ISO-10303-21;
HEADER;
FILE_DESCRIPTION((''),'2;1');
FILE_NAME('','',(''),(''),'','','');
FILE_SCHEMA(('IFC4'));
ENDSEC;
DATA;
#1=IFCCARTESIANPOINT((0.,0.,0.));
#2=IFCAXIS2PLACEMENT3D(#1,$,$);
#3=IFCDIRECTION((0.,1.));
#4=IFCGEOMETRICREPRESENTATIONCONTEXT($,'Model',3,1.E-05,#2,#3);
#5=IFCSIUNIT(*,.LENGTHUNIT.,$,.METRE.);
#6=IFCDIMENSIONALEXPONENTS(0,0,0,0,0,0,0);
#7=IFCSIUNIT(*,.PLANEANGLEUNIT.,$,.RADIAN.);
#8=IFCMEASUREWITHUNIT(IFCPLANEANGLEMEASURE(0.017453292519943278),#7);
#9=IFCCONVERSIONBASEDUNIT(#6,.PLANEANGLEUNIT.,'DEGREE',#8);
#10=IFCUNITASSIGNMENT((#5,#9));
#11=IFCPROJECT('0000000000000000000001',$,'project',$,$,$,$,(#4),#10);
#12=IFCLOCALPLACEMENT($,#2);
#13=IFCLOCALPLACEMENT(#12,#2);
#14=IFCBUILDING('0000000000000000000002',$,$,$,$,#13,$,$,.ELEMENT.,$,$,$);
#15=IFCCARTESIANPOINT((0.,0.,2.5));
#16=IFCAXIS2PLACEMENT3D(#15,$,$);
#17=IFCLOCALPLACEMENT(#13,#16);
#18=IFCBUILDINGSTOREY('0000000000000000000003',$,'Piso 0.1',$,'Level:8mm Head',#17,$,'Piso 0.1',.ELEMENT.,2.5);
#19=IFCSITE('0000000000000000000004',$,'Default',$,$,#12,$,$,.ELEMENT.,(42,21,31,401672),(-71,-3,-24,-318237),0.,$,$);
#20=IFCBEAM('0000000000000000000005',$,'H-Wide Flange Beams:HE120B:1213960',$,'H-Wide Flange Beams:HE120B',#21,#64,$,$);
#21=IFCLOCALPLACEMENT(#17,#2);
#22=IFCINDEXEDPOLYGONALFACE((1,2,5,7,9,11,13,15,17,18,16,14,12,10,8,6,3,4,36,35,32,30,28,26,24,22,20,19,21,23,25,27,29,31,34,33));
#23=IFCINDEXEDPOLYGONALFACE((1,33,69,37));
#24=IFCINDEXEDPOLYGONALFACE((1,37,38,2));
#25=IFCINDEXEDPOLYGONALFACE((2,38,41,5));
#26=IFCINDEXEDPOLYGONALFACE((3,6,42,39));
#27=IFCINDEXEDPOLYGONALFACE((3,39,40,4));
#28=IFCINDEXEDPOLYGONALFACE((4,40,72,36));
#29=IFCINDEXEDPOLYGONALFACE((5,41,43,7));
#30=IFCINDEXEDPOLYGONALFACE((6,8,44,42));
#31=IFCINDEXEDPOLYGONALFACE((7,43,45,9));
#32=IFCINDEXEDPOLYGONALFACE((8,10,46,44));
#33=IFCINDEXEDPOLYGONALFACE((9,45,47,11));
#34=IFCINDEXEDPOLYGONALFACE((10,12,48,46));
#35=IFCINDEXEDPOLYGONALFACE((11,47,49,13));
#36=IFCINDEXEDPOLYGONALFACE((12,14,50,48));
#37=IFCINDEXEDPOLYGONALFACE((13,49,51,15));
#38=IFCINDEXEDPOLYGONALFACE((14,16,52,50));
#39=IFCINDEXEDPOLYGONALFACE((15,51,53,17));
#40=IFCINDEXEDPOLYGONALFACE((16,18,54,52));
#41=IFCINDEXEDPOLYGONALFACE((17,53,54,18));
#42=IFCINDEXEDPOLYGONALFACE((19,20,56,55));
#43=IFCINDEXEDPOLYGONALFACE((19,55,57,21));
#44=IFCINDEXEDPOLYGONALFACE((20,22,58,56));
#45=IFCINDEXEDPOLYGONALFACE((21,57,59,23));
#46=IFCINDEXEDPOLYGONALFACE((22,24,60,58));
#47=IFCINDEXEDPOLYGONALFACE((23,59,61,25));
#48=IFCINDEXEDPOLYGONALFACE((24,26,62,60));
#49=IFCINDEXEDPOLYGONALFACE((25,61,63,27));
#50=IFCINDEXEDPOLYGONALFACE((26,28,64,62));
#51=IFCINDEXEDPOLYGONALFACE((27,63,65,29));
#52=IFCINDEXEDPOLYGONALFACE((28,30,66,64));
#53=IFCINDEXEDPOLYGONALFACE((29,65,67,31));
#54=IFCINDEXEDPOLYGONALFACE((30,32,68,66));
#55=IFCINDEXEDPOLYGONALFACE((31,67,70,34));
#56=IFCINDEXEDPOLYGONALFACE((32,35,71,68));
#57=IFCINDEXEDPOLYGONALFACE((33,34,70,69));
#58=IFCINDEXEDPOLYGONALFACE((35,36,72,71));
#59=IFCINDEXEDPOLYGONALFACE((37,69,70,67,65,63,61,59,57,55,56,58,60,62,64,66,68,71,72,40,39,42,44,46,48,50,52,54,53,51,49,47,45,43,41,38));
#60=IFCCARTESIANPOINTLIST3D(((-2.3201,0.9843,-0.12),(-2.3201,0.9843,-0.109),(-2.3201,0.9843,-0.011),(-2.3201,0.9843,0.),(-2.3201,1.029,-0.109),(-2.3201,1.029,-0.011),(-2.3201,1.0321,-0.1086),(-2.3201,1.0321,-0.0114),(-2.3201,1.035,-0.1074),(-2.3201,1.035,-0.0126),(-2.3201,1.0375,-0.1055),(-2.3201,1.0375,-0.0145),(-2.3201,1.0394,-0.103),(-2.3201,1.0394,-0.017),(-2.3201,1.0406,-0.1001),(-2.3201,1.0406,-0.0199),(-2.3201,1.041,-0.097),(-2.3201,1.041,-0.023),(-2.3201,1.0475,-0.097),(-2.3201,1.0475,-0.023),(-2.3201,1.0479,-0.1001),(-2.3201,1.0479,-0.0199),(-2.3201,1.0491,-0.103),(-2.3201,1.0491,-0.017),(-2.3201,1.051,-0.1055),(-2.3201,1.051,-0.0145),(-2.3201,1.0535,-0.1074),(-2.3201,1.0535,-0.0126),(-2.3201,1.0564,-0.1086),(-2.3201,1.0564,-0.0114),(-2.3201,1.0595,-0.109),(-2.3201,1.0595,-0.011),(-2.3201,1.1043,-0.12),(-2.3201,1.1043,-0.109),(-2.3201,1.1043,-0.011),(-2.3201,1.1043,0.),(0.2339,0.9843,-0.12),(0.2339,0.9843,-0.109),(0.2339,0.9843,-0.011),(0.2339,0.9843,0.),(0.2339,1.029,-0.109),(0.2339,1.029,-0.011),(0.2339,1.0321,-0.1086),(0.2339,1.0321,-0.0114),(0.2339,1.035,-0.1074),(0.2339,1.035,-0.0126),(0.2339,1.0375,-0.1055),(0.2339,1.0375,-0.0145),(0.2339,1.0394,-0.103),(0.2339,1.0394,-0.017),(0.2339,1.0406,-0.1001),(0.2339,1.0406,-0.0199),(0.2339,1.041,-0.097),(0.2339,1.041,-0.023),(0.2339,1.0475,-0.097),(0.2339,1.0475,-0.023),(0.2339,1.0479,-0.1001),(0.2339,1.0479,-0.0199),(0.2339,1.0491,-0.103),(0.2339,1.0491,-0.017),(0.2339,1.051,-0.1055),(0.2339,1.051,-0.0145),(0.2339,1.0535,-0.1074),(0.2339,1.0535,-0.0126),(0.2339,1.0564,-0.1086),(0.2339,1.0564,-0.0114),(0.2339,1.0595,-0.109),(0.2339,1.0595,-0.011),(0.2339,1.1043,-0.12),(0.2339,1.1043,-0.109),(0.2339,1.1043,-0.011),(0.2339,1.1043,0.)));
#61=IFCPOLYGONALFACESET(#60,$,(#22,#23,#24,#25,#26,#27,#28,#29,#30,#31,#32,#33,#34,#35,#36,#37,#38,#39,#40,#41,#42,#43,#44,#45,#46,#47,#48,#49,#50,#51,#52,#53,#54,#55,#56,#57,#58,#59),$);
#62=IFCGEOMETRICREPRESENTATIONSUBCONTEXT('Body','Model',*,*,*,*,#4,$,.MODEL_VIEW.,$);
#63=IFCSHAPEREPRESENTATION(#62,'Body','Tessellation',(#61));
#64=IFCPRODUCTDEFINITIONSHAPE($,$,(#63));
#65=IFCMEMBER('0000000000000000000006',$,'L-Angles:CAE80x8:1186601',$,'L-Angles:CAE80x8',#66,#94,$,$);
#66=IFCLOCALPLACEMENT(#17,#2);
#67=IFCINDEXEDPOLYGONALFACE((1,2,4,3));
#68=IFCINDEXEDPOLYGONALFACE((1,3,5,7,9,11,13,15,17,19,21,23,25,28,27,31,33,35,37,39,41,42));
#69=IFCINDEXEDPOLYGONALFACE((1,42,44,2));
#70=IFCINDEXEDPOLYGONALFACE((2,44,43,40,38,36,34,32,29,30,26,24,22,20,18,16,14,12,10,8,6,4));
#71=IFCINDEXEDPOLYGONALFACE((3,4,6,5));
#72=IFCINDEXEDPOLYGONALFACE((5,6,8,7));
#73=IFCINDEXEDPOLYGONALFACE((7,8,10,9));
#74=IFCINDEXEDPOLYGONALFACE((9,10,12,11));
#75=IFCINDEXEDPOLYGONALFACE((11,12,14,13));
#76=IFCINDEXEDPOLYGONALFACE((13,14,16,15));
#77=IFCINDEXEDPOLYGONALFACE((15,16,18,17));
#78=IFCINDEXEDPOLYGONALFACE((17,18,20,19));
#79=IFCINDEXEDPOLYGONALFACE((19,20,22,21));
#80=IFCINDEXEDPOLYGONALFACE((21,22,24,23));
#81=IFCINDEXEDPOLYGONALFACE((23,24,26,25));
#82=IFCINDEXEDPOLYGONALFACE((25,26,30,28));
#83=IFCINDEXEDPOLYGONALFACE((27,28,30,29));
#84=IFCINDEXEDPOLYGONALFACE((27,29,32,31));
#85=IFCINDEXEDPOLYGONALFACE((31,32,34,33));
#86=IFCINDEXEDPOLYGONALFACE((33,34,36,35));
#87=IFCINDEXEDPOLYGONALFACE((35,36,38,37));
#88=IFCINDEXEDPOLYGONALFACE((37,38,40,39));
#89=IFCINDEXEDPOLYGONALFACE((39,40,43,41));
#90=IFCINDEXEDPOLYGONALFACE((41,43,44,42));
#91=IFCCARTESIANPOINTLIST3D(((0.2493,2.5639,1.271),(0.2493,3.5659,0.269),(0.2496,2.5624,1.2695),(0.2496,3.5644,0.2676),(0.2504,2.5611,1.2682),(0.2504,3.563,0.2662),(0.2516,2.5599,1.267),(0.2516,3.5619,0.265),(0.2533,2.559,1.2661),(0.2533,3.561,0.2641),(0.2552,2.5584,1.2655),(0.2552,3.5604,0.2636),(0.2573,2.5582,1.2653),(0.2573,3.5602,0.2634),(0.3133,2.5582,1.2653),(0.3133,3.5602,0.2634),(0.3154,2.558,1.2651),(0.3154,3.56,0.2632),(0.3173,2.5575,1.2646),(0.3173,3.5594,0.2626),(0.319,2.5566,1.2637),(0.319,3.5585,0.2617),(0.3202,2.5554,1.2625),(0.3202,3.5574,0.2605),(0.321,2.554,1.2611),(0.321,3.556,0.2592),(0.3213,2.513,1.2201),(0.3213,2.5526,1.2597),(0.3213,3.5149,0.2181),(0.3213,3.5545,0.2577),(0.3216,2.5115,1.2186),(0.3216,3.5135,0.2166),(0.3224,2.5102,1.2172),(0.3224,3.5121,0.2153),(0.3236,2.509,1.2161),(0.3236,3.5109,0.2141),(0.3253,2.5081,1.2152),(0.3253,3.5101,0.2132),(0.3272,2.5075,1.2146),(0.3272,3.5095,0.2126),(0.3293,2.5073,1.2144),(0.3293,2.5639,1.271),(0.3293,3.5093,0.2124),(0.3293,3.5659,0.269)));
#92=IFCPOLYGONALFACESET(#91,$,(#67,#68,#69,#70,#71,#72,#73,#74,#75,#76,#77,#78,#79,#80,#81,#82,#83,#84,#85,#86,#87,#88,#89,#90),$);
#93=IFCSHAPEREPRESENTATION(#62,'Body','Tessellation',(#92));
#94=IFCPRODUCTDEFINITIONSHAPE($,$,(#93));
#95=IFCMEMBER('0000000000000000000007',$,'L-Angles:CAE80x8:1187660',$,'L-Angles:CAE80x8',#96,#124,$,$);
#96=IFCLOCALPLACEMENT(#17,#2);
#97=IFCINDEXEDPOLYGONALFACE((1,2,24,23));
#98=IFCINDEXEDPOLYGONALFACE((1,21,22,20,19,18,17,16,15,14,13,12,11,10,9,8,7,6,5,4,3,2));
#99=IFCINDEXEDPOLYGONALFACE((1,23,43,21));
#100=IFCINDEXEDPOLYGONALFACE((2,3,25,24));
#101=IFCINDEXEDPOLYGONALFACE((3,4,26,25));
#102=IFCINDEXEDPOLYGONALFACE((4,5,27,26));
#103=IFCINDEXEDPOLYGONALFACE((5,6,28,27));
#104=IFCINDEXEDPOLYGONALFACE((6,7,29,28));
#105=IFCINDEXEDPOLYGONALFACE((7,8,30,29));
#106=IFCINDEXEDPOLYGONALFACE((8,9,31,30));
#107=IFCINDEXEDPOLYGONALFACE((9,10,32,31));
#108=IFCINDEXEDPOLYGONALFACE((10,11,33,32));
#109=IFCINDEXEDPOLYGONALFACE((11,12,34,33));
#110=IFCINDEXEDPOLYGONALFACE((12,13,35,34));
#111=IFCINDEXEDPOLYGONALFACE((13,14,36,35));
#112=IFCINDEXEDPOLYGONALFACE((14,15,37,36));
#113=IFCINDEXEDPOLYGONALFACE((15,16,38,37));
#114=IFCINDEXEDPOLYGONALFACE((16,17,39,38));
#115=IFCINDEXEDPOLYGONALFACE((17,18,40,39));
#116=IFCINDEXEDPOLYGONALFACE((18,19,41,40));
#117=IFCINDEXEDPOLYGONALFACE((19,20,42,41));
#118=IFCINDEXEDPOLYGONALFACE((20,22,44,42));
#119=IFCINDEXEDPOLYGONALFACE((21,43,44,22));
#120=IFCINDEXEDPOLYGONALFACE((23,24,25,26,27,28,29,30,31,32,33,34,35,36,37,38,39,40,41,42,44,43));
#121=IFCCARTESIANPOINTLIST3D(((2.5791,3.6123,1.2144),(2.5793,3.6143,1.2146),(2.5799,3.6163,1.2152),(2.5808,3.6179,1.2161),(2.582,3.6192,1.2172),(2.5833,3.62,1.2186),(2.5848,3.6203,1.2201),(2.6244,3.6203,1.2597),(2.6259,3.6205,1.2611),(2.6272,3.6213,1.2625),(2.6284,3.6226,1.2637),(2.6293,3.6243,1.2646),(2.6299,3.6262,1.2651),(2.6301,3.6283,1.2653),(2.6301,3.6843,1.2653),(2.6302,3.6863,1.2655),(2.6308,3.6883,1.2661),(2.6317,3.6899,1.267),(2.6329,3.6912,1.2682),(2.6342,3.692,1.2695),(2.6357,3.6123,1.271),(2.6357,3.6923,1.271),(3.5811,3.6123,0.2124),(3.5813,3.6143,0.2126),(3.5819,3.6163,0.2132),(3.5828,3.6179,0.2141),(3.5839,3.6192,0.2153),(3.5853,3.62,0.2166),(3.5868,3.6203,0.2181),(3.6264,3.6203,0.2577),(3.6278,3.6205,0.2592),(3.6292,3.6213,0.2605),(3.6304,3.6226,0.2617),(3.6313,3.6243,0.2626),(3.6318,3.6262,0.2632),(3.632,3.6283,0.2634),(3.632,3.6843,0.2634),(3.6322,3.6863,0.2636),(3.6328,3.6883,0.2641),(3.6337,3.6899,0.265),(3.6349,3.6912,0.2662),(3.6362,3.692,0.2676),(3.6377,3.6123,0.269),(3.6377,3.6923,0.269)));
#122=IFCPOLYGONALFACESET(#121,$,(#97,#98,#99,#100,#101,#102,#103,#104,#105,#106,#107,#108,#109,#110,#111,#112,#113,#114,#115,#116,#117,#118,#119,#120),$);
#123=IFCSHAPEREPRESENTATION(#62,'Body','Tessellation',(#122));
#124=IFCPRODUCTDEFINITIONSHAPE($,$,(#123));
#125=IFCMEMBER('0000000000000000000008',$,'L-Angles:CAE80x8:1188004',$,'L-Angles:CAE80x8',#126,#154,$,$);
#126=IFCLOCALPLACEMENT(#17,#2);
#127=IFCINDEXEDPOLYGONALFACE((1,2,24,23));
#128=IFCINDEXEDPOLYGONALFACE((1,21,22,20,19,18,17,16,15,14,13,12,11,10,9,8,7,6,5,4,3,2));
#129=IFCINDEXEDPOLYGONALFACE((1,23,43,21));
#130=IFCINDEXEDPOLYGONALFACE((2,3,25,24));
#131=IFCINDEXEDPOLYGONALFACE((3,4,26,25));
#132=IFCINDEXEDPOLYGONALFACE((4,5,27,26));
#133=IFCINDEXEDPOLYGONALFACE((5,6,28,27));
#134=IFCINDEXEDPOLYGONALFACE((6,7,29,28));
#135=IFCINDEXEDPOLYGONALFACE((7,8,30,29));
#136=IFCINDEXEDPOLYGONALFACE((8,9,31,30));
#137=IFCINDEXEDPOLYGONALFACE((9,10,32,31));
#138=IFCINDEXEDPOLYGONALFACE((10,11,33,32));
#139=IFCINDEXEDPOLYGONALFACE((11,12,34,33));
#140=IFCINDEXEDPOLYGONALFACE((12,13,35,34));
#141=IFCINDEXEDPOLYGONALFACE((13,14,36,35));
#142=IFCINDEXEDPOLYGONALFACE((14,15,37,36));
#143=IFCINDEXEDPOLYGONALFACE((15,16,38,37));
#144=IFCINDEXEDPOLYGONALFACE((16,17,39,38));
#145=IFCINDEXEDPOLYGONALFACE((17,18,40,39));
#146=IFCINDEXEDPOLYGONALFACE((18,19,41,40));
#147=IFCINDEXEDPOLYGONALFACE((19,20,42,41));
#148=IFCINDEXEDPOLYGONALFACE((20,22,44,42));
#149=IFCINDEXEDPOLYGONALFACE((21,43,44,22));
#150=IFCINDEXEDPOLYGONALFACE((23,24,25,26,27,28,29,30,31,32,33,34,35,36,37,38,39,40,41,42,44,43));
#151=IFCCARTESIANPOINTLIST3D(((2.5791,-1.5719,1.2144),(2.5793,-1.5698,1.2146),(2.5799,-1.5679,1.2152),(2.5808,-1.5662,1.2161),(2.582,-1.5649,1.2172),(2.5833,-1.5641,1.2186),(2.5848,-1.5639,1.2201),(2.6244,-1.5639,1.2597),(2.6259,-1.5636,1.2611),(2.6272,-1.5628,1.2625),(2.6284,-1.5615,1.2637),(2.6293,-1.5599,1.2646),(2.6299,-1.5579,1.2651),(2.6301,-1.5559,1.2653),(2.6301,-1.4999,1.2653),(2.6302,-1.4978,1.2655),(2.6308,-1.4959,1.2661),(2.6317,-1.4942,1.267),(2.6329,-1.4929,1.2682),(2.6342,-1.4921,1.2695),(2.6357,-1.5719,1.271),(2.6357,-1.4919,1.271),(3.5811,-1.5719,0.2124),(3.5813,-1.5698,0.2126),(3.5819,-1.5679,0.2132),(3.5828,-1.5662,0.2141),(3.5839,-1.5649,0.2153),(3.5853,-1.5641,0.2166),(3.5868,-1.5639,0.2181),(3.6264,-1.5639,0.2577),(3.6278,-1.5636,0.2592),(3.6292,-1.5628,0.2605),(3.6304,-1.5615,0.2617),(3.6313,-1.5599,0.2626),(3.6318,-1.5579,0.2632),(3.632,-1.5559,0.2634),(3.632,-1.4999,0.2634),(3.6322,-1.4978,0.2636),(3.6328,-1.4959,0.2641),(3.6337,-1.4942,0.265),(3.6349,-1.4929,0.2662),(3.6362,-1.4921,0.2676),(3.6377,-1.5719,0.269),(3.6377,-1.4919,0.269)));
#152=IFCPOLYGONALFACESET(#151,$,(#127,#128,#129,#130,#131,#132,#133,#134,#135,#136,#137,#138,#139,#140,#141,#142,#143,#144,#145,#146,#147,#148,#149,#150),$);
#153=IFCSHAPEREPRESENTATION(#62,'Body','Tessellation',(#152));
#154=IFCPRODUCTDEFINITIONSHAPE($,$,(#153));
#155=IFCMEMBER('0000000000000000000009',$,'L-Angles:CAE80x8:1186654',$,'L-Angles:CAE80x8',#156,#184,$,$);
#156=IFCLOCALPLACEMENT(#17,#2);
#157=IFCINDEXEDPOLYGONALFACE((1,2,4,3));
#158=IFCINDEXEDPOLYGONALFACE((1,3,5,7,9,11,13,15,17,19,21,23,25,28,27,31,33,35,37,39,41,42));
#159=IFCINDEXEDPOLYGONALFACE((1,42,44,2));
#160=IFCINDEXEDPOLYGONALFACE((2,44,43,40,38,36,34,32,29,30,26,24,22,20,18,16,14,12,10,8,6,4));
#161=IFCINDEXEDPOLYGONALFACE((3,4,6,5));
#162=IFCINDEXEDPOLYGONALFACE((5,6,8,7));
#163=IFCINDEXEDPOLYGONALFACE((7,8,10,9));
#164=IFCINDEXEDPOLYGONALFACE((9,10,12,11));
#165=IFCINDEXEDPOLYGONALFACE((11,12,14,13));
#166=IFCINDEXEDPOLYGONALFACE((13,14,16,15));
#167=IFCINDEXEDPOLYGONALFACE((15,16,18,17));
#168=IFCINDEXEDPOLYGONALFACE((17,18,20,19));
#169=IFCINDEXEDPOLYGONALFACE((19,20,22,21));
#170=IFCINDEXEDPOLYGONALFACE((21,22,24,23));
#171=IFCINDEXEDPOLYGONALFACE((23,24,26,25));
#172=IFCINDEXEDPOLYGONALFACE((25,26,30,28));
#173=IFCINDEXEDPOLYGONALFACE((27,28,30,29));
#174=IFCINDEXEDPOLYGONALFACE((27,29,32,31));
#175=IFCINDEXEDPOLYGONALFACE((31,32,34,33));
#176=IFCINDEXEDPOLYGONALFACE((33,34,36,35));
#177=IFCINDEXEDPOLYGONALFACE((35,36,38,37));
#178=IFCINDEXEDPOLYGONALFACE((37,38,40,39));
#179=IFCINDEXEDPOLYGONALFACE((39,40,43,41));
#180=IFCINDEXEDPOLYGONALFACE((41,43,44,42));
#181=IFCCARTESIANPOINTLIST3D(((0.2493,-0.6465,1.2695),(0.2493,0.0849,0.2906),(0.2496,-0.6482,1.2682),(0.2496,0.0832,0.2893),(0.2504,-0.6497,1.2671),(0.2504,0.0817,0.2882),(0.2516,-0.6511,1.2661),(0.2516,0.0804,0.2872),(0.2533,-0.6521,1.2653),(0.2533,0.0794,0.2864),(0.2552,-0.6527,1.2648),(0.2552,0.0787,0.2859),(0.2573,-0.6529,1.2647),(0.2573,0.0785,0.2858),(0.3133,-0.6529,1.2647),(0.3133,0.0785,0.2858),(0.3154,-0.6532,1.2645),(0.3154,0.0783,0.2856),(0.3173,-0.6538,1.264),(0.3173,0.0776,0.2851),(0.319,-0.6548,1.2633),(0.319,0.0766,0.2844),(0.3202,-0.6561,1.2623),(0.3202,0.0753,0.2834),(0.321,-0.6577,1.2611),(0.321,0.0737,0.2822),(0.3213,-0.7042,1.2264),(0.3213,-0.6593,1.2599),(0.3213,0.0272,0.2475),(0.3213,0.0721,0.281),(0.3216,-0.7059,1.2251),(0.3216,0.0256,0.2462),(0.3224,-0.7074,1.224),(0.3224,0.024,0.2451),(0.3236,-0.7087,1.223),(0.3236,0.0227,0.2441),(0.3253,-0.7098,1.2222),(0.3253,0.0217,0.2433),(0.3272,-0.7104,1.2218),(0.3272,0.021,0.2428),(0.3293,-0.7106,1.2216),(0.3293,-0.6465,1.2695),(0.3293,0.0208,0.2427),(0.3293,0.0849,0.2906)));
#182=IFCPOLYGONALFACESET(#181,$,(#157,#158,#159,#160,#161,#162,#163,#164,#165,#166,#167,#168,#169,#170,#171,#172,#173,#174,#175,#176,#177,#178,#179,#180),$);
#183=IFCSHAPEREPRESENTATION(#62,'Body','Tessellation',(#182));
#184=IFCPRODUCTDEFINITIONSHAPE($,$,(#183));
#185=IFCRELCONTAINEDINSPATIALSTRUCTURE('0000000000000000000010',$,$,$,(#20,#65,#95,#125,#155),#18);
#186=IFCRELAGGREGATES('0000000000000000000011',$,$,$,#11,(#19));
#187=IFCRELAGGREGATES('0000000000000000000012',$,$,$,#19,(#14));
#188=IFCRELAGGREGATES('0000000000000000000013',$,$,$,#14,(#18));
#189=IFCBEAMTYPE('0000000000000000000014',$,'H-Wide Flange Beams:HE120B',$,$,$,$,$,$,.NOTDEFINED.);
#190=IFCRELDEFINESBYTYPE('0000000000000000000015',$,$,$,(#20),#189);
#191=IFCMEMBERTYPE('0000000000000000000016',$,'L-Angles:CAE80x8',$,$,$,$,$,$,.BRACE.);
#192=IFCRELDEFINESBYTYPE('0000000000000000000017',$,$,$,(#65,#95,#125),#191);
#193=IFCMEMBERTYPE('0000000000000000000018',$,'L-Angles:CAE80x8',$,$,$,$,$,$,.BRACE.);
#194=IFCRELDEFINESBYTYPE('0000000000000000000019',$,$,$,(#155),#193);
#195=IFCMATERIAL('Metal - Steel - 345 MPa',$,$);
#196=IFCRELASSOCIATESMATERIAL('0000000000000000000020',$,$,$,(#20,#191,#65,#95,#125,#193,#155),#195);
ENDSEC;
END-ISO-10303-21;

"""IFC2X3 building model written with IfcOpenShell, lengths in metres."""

from ifc_helpers import new_model, entity, si_unit, converted_unit, direction, frame, frame_2d, origin, place, context, subcontext, project, spatial, polyline, circle_curve, parameter, trimmed, segment, composite_curve, i_section, outline, extrude, source, transform, mapped, material, type_object, type_shapes, element, save


model = new_model("IFC2X3")

# Units and contexts
model_context = context("Model", 3, precision=1e-05, world=origin(), true_north=direction((0.0, 1.0)))
body_context = subcontext(model_context, "Body", "Model", "MODEL_VIEW")
ifc_project = project(units=[si_unit("LENGTHUNIT", "METRE"), converted_unit("PLANEANGLEUNIT", "DEGREE", entity("IfcPlaneAngleMeasure", 0.017453292519943278), si_unit("PLANEANGLEUNIT", "RADIAN"), dimensions=[0, 0, 0, 0, 0, 0, 0])], contexts=[model_context])

# Site, building, storey
site_placement = place(None, origin())
site = spatial("IfcSite", under=ifc_project, at=site_placement, Name="Default", CompositionType="ELEMENT", RefLatitude=(42, 21, 31, 401672), RefLongitude=(-71, -3, -24, -318237), RefElevation=0.0)
building_placement = place(site_placement, origin())
building = spatial("IfcBuilding", under=site, at=building_placement, CompositionType="ELEMENT")
storey_placement = place(building_placement, frame((0.0, 0.0, 2.5)))
storey = spatial("IfcBuildingStorey", under=building, at=storey_placement, Name="Piso 0.1", ObjectType="Level:8mm Head", LongName="Piso 0.1", CompositionType="ELEMENT", Elevation=2.5)

# Shared definitions
ifc_material_1 = material(Name="Metal - Steel - 345 MPa")

# Beam
beam_type = type_object("IfcBeamType", Name="H-Wide Flange Beams:HE120B", PredefinedType="NOTDEFINED")
beam_1_placement = place(storey_placement, frame((-2.3929, 1.0443, 0.0)))
element("IfcBeam", 1, at=beam_1_placement, inside=storey, type_object=beam_type, material=ifc_material_1, Name="H-Wide Flange Beams:HE120B:1213960", ObjectType="H-Wide Flange Beams:HE120B", context=body_context, shape_type="SweptSolid", body=[
    extrude(i_section(OverallWidth=0.12, OverallDepth=0.12, WebThickness=0.0065, FlangeThickness=0.011, FilletRadius=0.012, at=frame_2d((0.0, 0.0), x_axis=(0.0, 1.0))), frame((0.0728, 0.0, -0.06), z_axis=(1.0, 0.0, 0.0), x_axis=(0.0, 0.0, -1.0)), (0.0, 0.0, 1.0), 2.554),
])

# Members
member_type_1 = type_object("IfcMemberType", Name="L-Angles:CAE80x8", PredefinedType="BRACE", material=ifc_material_1)
shared_shape_1 = source(origin(), body_context, "Body", "SweptSolid", [
    extrude(outline(composite_curve([segment(polyline([(-0.0263, -0.0263), (0.0537, -0.0263)]), True, "CONTINUOUS"), segment(trimmed(circle_curve(frame_2d((0.0457, -0.0263), x_axis=(1.0, 0.0)), 0.008), [parameter(0.0)], [parameter(90.0)], True, "PARAMETER"), True, "CONTINUOUS"), segment(polyline([(0.0457, -0.0183), (-0.0103, -0.0183)]), True, "CONTINUOUS"), segment(trimmed(circle_curve(frame_2d((-0.0103, -0.0103), x_axis=(1.0, 0.0)), 0.008), [parameter(180.0)], [parameter(270.0)], True, "PARAMETER"), False, "CONTINUOUS"), segment(polyline([(-0.0183, -0.0103), (-0.0183, 0.0457)]), True, "CONTINUOUS"), segment(trimmed(circle_curve(frame_2d((-0.0263, 0.0457), x_axis=(1.0, 0.0)), 0.008), [parameter(0.0)], [parameter(90.0)], True, "PARAMETER"), True, "CONTINUOUS"), segment(polyline([(-0.0263, 0.0537), (-0.0263, -0.0263)]), True, "CONTINUOUS")], self_intersect=False)), frame((-0.7085, -0.0037, -0.0037), z_axis=(1.0, 0.0, 0.0), x_axis=(0.0, -1.0, 0.0)), (0.0, 0.0, 1.0), 1.417),
])
type_shapes(member_type_1, [shared_shape_1])
for number, where, z_axis, x_axis, name in (
    (2, (0.3067, 3.0489, 0.754), (0.0, 0.707107, 0.707107), (0.0, -0.707107, 0.707107), "L-Angles:CAE80x8:1186601"),
    (3, (3.1207, 3.6349, 0.754), (0.707107, 0.0, 0.707107), (-0.707107, 0.0, 0.707107), "L-Angles:CAE80x8:1187660"),
    (4, (3.1207, -1.5493, 0.754), (0.707107, 0.0, 0.707107), (-0.707107, 0.0, 0.707107), "L-Angles:CAE80x8:1188004"),
):
    element("IfcMember", number, at=place(storey_placement, frame(where, z_axis=z_axis, x_axis=x_axis)), inside=storey, type_object=member_type_1, material=ifc_material_1, Name=name, ObjectType="L-Angles:CAE80x8", context=body_context, shape_type="MappedRepresentation", body=[
        mapped(shared_shape_1, transform((0.0, 0.0, 0.0), scale=1.0)),
    ])
member_type_2 = type_object("IfcMemberType", Name="L-Angles:CAE80x8", PredefinedType="BRACE", material=ifc_material_1)
shared_shape_2 = source(origin(), body_context, "Body", "SweptSolid", [
    extrude(outline(composite_curve([segment(polyline([(-0.0263, -0.0263), (0.0537, -0.0263)]), True, "CONTINUOUS"), segment(trimmed(circle_curve(frame_2d((0.0457, -0.0263), x_axis=(1.0, 0.0)), 0.008), [parameter(0.0)], [parameter(90.0)], True, "PARAMETER"), True, "CONTINUOUS"), segment(polyline([(0.0457, -0.0183), (-0.0103, -0.0183)]), True, "CONTINUOUS"), segment(trimmed(circle_curve(frame_2d((-0.0103, -0.0103), x_axis=(1.0, 0.0)), 0.008), [parameter(180.0)], [parameter(270.0)], True, "PARAMETER"), False, "CONTINUOUS"), segment(polyline([(-0.0183, -0.0103), (-0.0183, 0.0457)]), True, "CONTINUOUS"), segment(trimmed(circle_curve(frame_2d((-0.0263, 0.0457), x_axis=(1.0, 0.0)), 0.008), [parameter(0.0)], [parameter(90.0)], True, "PARAMETER"), True, "CONTINUOUS"), segment(polyline([(-0.0263, 0.0537), (-0.0263, -0.0263)]), True, "CONTINUOUS")], self_intersect=False)), frame((-0.5985, -0.0037, -0.0037), z_axis=(1.0, 0.0, 0.0), x_axis=(0.0, -1.0, 0.0)), (0.0, 0.0, 1.0), 1.222),
])
type_shapes(member_type_2, [shared_shape_2])
member_1_placement = place(storey_placement, frame((0.3067, -0.2914, 0.7565), z_axis=(0.0, 0.801082, 0.598555), x_axis=(0.0, -0.598555, 0.801082)))
element("IfcMember", 5, at=member_1_placement, inside=storey, type_object=member_type_2, material=ifc_material_1, Name="L-Angles:CAE80x8:1186654", ObjectType="L-Angles:CAE80x8", context=body_context, shape_type="MappedRepresentation", body=[
    mapped(shared_shape_2, transform((0.0, 0.0, 0.0), scale=1.0)),
])

save(model, "model.ifc")
